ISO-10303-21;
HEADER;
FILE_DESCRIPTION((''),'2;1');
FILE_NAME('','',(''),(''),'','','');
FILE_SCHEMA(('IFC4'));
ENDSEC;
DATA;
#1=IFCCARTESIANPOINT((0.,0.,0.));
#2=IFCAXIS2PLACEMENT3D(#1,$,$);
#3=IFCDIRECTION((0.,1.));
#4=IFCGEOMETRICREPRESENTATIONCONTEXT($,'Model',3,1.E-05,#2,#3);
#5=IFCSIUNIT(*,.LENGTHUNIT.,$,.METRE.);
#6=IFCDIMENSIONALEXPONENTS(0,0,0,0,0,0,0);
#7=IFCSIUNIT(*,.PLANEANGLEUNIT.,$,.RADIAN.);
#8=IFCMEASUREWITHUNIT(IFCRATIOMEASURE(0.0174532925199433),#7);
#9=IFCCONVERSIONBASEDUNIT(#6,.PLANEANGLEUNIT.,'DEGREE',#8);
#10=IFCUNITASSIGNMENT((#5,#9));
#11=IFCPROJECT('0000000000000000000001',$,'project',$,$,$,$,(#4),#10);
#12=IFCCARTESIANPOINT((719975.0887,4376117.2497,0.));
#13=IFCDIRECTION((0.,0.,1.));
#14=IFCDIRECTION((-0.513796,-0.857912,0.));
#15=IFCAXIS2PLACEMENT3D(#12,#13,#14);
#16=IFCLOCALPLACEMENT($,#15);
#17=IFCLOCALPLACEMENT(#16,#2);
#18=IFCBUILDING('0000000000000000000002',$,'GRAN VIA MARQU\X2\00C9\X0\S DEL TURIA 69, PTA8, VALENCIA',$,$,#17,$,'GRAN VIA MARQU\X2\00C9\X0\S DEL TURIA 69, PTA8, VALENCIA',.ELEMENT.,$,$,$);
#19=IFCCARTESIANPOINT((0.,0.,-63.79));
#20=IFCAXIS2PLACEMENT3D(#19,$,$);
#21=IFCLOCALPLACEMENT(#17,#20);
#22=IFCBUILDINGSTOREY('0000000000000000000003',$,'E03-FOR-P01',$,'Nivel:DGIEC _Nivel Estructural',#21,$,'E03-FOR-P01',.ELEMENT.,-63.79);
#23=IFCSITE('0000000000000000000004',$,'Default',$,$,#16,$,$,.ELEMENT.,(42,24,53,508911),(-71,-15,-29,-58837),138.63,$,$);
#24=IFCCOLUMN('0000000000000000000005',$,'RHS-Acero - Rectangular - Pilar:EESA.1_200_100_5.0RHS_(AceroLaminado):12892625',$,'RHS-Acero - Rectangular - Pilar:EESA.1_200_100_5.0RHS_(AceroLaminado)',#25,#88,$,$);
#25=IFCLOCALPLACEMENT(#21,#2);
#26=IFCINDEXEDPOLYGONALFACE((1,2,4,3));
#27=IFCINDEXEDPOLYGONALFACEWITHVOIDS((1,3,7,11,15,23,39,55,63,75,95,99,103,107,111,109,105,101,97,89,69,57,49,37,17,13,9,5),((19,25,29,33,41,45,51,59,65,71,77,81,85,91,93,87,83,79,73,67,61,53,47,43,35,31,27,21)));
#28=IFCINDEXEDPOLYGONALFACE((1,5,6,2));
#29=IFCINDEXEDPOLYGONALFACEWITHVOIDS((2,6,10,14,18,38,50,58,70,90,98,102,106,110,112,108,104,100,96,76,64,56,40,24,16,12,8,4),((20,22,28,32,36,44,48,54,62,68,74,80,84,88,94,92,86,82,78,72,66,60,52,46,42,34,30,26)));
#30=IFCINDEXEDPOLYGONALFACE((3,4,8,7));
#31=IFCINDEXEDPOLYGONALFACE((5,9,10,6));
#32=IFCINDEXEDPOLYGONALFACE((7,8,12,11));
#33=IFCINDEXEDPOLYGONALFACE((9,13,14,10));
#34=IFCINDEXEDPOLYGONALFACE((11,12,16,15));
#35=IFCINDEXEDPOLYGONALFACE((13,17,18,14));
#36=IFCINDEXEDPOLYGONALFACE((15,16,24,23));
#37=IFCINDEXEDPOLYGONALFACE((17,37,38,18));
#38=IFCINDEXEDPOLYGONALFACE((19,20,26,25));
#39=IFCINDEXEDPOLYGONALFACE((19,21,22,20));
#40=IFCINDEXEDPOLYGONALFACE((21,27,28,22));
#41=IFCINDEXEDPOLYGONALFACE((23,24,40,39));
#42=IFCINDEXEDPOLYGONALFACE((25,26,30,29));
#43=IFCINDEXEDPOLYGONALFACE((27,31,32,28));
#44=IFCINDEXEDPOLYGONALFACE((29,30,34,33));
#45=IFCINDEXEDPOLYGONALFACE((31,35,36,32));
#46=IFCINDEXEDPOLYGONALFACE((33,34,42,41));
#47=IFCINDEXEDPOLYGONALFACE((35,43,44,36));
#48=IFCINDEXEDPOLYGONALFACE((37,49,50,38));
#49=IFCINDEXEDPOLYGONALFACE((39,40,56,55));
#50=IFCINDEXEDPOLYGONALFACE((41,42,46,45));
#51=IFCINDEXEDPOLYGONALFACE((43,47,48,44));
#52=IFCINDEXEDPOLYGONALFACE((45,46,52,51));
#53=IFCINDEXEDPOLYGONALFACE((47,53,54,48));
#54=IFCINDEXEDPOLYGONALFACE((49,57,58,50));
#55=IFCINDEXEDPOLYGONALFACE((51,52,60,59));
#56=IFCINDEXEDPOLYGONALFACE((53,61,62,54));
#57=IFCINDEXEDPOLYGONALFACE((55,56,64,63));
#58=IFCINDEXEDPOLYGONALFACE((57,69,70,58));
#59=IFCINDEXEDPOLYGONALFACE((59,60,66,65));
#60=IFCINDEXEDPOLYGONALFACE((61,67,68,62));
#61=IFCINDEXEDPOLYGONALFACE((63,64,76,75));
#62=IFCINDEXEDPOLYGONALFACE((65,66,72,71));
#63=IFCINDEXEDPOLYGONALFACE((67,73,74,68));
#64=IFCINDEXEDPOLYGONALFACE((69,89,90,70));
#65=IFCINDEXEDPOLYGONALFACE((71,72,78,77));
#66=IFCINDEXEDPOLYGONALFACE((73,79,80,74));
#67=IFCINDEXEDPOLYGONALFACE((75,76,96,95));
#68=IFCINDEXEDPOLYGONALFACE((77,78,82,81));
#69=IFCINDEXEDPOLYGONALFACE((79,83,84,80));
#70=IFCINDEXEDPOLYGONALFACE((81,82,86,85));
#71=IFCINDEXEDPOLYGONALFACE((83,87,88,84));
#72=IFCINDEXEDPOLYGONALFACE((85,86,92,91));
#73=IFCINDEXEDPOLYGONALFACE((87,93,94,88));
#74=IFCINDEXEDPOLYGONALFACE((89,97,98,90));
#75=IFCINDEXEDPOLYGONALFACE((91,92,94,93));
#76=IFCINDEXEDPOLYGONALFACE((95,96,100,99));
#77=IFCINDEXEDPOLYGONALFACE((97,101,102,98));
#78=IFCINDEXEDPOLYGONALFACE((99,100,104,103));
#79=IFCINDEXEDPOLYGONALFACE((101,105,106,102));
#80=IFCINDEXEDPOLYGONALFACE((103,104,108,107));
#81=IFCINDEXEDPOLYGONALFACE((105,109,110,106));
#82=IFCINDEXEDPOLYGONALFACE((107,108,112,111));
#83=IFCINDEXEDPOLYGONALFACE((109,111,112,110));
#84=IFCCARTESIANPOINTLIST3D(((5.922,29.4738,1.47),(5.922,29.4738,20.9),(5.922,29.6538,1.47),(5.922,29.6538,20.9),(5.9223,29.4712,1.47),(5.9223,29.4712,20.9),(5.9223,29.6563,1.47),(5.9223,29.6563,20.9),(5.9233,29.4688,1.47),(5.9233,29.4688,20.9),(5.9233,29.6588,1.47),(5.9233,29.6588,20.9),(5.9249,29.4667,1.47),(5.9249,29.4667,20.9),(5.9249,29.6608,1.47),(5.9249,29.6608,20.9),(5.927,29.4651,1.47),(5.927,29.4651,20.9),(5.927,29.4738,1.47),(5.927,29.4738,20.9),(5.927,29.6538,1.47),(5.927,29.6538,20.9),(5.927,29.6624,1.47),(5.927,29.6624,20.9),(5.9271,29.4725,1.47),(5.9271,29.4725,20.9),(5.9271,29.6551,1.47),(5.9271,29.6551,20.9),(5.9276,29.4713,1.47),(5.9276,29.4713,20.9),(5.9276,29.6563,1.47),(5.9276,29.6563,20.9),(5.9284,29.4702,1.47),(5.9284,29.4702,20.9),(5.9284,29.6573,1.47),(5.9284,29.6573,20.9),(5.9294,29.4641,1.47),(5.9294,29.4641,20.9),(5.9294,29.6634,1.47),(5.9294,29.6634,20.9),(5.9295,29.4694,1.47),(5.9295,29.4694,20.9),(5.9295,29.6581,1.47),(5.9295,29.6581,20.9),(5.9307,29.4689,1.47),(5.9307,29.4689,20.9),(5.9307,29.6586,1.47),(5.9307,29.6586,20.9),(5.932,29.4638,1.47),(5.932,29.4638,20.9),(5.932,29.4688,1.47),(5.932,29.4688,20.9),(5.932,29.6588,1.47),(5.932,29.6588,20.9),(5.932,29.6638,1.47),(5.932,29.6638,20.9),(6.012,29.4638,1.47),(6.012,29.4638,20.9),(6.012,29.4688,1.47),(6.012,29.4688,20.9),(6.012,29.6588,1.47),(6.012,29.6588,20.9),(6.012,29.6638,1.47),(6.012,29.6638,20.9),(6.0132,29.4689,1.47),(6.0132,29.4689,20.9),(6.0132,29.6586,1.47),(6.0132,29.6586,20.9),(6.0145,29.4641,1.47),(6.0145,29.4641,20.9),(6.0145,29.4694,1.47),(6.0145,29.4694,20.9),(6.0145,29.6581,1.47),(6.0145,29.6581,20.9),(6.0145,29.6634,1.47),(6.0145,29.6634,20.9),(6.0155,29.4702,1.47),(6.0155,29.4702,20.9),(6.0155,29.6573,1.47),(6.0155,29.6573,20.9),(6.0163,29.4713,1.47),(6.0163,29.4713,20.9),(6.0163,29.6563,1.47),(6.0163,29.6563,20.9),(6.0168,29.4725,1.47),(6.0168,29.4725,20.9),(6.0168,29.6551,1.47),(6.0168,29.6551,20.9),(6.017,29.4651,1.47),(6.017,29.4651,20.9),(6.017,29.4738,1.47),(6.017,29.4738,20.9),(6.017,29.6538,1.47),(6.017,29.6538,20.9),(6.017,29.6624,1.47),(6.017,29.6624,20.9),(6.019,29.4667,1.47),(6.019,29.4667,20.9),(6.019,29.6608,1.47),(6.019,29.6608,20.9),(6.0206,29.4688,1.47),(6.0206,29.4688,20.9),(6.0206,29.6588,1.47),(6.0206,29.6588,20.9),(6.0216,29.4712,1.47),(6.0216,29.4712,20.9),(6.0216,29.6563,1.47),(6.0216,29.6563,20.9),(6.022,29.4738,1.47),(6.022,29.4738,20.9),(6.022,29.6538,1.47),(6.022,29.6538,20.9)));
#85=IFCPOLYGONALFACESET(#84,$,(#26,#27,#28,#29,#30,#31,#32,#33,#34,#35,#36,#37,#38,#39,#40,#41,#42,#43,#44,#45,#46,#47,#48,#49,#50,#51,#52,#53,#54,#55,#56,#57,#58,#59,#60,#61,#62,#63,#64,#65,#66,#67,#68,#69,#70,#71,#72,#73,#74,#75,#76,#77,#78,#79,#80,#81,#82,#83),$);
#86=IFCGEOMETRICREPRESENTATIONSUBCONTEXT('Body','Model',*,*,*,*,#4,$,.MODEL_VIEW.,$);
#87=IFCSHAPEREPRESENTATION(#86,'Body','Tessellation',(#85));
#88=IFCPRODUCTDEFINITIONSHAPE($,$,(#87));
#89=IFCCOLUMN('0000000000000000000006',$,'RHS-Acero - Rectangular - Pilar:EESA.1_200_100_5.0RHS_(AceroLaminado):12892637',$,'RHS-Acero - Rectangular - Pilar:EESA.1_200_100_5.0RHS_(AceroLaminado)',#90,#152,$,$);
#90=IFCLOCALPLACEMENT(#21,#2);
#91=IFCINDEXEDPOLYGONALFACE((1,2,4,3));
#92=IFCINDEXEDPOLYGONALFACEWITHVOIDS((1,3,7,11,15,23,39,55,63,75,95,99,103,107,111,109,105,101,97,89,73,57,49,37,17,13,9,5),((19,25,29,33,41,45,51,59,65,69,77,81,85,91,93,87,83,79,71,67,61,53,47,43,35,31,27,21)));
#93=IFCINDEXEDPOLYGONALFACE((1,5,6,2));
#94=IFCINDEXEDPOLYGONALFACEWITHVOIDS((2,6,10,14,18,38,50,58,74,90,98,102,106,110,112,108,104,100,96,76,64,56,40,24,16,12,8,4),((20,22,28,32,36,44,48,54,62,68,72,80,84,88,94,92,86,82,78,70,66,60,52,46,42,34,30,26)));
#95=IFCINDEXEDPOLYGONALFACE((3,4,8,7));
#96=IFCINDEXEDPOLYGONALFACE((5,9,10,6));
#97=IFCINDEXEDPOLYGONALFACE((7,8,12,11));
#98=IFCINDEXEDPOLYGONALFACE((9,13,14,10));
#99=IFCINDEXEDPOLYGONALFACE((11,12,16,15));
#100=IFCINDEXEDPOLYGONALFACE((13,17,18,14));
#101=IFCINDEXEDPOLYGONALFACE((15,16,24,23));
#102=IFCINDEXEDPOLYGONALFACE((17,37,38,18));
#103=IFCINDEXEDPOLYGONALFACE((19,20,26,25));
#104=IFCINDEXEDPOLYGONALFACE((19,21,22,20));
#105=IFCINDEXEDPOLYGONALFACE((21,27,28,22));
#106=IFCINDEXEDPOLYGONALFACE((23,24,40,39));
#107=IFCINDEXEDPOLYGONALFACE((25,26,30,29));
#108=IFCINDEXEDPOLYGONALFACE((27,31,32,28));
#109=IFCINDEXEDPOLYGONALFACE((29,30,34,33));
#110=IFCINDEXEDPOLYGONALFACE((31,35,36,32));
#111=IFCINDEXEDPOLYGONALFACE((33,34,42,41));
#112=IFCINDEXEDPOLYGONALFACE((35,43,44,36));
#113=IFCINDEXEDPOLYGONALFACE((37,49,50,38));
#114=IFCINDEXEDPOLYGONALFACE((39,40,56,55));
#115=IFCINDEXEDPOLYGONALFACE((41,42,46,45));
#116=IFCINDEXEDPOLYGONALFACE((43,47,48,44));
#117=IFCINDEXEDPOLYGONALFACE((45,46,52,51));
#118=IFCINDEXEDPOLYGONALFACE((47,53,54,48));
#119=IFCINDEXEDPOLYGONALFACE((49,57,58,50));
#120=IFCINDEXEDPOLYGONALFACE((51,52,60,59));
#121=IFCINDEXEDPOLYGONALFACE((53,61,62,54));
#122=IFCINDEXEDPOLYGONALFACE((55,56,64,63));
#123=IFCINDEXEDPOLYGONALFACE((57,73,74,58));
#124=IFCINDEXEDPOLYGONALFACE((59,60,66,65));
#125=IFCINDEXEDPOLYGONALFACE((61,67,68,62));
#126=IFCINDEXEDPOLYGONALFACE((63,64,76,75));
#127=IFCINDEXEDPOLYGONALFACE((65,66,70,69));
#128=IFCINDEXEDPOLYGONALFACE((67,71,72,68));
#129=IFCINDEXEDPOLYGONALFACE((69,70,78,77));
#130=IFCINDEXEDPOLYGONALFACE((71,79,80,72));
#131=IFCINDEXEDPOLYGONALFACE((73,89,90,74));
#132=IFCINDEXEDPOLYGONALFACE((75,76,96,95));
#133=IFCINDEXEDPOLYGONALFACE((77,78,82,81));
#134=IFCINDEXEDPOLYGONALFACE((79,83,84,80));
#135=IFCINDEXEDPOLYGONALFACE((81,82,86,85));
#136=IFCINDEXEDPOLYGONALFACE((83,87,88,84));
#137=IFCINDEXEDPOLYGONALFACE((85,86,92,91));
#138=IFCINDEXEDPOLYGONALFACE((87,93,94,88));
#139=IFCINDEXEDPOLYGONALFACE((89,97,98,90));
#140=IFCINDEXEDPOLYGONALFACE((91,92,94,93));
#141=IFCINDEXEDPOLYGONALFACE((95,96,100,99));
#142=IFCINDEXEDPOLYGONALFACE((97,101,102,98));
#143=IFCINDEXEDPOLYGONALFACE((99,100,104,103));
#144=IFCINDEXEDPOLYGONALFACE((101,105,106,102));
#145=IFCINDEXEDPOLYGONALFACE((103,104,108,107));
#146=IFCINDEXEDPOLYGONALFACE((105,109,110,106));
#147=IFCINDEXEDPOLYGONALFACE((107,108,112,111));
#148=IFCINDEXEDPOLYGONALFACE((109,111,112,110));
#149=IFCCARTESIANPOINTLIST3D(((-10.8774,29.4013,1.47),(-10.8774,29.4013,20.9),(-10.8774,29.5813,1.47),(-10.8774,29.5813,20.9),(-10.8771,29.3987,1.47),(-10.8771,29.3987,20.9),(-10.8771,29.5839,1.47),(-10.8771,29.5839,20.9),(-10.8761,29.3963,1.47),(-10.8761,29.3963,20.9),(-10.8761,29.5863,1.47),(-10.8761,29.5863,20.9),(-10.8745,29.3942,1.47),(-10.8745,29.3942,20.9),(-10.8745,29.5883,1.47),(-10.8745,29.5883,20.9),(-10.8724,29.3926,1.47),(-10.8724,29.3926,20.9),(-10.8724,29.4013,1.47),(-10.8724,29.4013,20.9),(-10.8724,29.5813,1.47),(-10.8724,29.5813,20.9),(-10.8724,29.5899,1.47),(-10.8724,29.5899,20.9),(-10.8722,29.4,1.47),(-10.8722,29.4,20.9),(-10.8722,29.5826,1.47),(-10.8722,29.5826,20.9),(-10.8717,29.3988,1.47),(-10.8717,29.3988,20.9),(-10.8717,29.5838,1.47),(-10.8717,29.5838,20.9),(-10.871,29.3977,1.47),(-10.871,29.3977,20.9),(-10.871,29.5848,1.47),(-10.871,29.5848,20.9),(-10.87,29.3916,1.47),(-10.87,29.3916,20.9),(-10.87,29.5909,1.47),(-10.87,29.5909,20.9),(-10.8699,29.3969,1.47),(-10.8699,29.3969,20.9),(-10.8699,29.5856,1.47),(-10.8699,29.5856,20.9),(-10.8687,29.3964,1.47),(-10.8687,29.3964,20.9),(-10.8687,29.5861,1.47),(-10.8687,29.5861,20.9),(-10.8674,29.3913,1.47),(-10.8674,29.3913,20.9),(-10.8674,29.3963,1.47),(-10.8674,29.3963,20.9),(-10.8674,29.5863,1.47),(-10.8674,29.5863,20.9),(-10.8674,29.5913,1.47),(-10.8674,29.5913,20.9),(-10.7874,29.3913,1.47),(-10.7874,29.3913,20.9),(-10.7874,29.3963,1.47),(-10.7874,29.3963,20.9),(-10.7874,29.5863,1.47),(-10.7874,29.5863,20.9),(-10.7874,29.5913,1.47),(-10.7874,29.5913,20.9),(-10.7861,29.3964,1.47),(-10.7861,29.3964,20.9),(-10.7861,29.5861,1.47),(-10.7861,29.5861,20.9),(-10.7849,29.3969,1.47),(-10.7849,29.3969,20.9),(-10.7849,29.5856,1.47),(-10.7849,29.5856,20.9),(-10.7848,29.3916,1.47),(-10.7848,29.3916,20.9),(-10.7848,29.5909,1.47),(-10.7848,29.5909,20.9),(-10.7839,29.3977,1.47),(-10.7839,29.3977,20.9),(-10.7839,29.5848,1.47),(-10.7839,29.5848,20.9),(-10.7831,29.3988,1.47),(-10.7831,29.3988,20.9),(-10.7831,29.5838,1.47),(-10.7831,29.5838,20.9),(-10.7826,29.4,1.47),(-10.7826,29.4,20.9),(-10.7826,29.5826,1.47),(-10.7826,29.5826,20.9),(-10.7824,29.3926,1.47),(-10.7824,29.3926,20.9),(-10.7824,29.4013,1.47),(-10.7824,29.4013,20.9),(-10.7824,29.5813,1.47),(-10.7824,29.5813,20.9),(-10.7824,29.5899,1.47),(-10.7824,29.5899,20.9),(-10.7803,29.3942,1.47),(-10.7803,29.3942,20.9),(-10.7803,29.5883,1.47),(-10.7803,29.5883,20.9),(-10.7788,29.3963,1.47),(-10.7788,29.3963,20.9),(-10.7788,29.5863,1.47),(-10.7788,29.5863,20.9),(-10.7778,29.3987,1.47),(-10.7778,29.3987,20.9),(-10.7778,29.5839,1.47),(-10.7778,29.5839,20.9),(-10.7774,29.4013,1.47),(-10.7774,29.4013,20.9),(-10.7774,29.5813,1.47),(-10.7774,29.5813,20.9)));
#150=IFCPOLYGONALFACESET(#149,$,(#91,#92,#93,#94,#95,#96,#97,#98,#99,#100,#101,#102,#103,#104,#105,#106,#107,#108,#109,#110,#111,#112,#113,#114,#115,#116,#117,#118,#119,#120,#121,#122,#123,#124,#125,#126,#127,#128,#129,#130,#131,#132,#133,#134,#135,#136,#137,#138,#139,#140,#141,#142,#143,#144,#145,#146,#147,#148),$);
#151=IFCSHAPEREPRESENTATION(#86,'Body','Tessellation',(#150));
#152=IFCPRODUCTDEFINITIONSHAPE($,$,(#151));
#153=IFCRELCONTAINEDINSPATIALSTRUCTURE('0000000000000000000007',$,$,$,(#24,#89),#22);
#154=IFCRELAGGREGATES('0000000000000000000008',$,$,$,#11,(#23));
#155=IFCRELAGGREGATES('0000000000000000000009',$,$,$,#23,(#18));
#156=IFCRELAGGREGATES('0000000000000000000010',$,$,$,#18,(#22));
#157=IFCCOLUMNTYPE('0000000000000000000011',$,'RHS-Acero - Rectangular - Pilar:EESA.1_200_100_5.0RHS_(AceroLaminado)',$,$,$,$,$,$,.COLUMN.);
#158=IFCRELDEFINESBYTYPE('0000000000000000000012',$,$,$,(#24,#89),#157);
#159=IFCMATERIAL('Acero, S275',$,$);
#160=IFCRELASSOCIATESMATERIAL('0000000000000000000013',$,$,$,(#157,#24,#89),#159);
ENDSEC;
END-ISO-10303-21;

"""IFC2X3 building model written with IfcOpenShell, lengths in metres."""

from ifc_helpers import new_model, entity, si_unit, converted_unit, direction, frame, frame_2d, origin, place, context, subcontext, project, spatial, polyline, circle_curve, parameter, trimmed, segment, composite_curve, outline, extrude, source, transform, mapped, material, type_object, type_shapes, element, save


model = new_model("IFC2X3")

# Units and contexts
model_context = context("Model", 3, precision=1e-05, world=origin(), true_north=direction((0.0, 1.0)))
body_context = subcontext(model_context, "Body", "Model", "MODEL_VIEW")
ifc_project = project(units=[si_unit("LENGTHUNIT", "METRE"), converted_unit("PLANEANGLEUNIT", "DEGREE", entity("IfcRatioMeasure", 0.0174532925199433), si_unit("PLANEANGLEUNIT", "RADIAN"), dimensions=[0, 0, 0, 0, 0, 0, 0])], contexts=[model_context])

# Site, building, storey
site_placement = place(None, frame((719975.0887, 4376117.2497, 0.0), z_axis=(0.0, 0.0, 1.0), x_axis=(-0.513796, -0.857912, 0.0)))
site = spatial("IfcSite", under=ifc_project, at=site_placement, Name="Default", CompositionType="ELEMENT", RefLatitude=(42, 24, 53, 508911), RefLongitude=(-71, -15, -29, -58837), RefElevation=138.63)
building_placement = place(site_placement, origin())
building = spatial("IfcBuilding", under=site, at=building_placement, Name="GRAN VIA MARQUÉS DEL TURIA 69, PTA8, VALENCIA", LongName="GRAN VIA MARQUÉS DEL TURIA 69, PTA8, VALENCIA", CompositionType="ELEMENT")
storey_placement = place(building_placement, frame((0.0, 0.0, -63.79)))
storey = spatial("IfcBuildingStorey", under=building, at=storey_placement, Name="E03-FOR-P01", ObjectType="Nivel:DGIEC _Nivel Estructural", LongName="E03-FOR-P01", CompositionType="ELEMENT", Elevation=-63.79)

# Columns
ifc_material_1 = material(Name="Acero, S275")
column_type_1 = type_object("IfcColumnType", Name="RHS-Acero - Rectangular - Pilar:EESA.1_200_100_5.0RHS_(AceroLaminado)", PredefinedType="COLUMN", material=ifc_material_1)
shared_shape_1 = source(origin(), body_context, "Body", "SweptSolid", [
    extrude(outline(composite_curve([segment(polyline([(-0.04, -0.1), (0.04, -0.1)]), True, "CONTINUOUS"), segment(trimmed(circle_curve(frame_2d((0.04, -0.09), x_axis=(-1.0, 0.0)), 0.01), [parameter(90.0)], [parameter(180.0)], True, "PARAMETER"), True, "CONTINUOUS"), segment(polyline([(0.05, -0.09), (0.05, 0.09)]), True, "CONTINUOUS"), segment(trimmed(circle_curve(frame_2d((0.04, 0.09), x_axis=(-1.0, 0.0)), 0.01), [parameter(180.0)], [parameter(270.0)], True, "PARAMETER"), True, "CONTINUOUS"), segment(polyline([(0.04, 0.1), (-0.04, 0.1)]), True, "CONTINUOUS"), segment(trimmed(circle_curve(frame_2d((-0.04, 0.09), x_axis=(-1.0, 0.0)), 0.01), [parameter(270.0)], [parameter(360.0)], True, "PARAMETER"), True, "CONTINUOUS"), segment(polyline([(-0.05, 0.09), (-0.05, -0.09)]), True, "CONTINUOUS"), segment(trimmed(circle_curve(frame_2d((-0.04, -0.09), x_axis=(-1.0, 0.0)), 0.01), [parameter(360.0)], [parameter(90.0)], True, "PARAMETER"), True, "CONTINUOUS")], self_intersect=False), holes=[composite_curve([segment(trimmed(circle_curve(frame_2d((-0.04, -0.09), x_axis=(-1.0, 0.0)), 0.005), [parameter(0.0)], [parameter(90.0)], True, "PARAMETER"), False, "CONTINUOUS"), segment(polyline([(-0.045, -0.09), (-0.045, 0.09)]), True, "CONTINUOUS"), segment(trimmed(circle_curve(frame_2d((-0.04, 0.09), x_axis=(-1.0, 0.0)), 0.005), [parameter(270.0)], [parameter(0.0)], True, "PARAMETER"), False, "CONTINUOUS"), segment(polyline([(-0.04, 0.095), (0.04, 0.095)]), True, "CONTINUOUS"), segment(trimmed(circle_curve(frame_2d((0.04, 0.09), x_axis=(-1.0, 0.0)), 0.005), [parameter(180.0)], [parameter(270.0)], True, "PARAMETER"), False, "CONTINUOUS"), segment(polyline([(0.045, 0.09), (0.045, -0.09)]), True, "CONTINUOUS"), segment(trimmed(circle_curve(frame_2d((0.04, -0.09), x_axis=(-1.0, 0.0)), 0.005), [parameter(90.0)], [parameter(180.0)], True, "PARAMETER"), False, "CONTINUOUS"), segment(polyline([(0.04, -0.095), (-0.04, -0.095)]), True, "CONTINUOUS")], self_intersect=False)]), frame((0.0, 0.0, -62.32), z_axis=(0.0, 0.0, 1.0), x_axis=(-1.0, 0.0, 0.0)), (0.0, 0.0, 1.0), 19.43),
])
type_shapes(column_type_1, [shared_shape_1])
for number, where, z_axis, x_axis, name in (
    (1, (5.972, 29.5638, 63.79), (0.0, 0.0, 1.0), (-1.0, 0.0, 0.0), "RHS-Acero - Rectangular - Pilar:EESA.1_200_100_5.0RHS_(AceroLaminado):12892625"),
    (2, (-10.8274, 29.4913, 63.79), (0.0, 0.0, 1.0), (-1.0, 0.0, 0.0), "RHS-Acero - Rectangular - Pilar:EESA.1_200_100_5.0RHS_(AceroLaminado):12892637"),
):
    element("IfcColumn", number, at=place(storey_placement, frame(where, z_axis=z_axis, x_axis=x_axis)), inside=storey, type_object=column_type_1, material=ifc_material_1, Name=name, ObjectType="RHS-Acero - Rectangular - Pilar:EESA.1_200_100_5.0RHS_(AceroLaminado)", context=body_context, shape_type="MappedRepresentation", body=[
        mapped(shared_shape_1, transform((0.0, 0.0, 0.0), scale=1.0)),
    ])

save(model, "model.ifc")
